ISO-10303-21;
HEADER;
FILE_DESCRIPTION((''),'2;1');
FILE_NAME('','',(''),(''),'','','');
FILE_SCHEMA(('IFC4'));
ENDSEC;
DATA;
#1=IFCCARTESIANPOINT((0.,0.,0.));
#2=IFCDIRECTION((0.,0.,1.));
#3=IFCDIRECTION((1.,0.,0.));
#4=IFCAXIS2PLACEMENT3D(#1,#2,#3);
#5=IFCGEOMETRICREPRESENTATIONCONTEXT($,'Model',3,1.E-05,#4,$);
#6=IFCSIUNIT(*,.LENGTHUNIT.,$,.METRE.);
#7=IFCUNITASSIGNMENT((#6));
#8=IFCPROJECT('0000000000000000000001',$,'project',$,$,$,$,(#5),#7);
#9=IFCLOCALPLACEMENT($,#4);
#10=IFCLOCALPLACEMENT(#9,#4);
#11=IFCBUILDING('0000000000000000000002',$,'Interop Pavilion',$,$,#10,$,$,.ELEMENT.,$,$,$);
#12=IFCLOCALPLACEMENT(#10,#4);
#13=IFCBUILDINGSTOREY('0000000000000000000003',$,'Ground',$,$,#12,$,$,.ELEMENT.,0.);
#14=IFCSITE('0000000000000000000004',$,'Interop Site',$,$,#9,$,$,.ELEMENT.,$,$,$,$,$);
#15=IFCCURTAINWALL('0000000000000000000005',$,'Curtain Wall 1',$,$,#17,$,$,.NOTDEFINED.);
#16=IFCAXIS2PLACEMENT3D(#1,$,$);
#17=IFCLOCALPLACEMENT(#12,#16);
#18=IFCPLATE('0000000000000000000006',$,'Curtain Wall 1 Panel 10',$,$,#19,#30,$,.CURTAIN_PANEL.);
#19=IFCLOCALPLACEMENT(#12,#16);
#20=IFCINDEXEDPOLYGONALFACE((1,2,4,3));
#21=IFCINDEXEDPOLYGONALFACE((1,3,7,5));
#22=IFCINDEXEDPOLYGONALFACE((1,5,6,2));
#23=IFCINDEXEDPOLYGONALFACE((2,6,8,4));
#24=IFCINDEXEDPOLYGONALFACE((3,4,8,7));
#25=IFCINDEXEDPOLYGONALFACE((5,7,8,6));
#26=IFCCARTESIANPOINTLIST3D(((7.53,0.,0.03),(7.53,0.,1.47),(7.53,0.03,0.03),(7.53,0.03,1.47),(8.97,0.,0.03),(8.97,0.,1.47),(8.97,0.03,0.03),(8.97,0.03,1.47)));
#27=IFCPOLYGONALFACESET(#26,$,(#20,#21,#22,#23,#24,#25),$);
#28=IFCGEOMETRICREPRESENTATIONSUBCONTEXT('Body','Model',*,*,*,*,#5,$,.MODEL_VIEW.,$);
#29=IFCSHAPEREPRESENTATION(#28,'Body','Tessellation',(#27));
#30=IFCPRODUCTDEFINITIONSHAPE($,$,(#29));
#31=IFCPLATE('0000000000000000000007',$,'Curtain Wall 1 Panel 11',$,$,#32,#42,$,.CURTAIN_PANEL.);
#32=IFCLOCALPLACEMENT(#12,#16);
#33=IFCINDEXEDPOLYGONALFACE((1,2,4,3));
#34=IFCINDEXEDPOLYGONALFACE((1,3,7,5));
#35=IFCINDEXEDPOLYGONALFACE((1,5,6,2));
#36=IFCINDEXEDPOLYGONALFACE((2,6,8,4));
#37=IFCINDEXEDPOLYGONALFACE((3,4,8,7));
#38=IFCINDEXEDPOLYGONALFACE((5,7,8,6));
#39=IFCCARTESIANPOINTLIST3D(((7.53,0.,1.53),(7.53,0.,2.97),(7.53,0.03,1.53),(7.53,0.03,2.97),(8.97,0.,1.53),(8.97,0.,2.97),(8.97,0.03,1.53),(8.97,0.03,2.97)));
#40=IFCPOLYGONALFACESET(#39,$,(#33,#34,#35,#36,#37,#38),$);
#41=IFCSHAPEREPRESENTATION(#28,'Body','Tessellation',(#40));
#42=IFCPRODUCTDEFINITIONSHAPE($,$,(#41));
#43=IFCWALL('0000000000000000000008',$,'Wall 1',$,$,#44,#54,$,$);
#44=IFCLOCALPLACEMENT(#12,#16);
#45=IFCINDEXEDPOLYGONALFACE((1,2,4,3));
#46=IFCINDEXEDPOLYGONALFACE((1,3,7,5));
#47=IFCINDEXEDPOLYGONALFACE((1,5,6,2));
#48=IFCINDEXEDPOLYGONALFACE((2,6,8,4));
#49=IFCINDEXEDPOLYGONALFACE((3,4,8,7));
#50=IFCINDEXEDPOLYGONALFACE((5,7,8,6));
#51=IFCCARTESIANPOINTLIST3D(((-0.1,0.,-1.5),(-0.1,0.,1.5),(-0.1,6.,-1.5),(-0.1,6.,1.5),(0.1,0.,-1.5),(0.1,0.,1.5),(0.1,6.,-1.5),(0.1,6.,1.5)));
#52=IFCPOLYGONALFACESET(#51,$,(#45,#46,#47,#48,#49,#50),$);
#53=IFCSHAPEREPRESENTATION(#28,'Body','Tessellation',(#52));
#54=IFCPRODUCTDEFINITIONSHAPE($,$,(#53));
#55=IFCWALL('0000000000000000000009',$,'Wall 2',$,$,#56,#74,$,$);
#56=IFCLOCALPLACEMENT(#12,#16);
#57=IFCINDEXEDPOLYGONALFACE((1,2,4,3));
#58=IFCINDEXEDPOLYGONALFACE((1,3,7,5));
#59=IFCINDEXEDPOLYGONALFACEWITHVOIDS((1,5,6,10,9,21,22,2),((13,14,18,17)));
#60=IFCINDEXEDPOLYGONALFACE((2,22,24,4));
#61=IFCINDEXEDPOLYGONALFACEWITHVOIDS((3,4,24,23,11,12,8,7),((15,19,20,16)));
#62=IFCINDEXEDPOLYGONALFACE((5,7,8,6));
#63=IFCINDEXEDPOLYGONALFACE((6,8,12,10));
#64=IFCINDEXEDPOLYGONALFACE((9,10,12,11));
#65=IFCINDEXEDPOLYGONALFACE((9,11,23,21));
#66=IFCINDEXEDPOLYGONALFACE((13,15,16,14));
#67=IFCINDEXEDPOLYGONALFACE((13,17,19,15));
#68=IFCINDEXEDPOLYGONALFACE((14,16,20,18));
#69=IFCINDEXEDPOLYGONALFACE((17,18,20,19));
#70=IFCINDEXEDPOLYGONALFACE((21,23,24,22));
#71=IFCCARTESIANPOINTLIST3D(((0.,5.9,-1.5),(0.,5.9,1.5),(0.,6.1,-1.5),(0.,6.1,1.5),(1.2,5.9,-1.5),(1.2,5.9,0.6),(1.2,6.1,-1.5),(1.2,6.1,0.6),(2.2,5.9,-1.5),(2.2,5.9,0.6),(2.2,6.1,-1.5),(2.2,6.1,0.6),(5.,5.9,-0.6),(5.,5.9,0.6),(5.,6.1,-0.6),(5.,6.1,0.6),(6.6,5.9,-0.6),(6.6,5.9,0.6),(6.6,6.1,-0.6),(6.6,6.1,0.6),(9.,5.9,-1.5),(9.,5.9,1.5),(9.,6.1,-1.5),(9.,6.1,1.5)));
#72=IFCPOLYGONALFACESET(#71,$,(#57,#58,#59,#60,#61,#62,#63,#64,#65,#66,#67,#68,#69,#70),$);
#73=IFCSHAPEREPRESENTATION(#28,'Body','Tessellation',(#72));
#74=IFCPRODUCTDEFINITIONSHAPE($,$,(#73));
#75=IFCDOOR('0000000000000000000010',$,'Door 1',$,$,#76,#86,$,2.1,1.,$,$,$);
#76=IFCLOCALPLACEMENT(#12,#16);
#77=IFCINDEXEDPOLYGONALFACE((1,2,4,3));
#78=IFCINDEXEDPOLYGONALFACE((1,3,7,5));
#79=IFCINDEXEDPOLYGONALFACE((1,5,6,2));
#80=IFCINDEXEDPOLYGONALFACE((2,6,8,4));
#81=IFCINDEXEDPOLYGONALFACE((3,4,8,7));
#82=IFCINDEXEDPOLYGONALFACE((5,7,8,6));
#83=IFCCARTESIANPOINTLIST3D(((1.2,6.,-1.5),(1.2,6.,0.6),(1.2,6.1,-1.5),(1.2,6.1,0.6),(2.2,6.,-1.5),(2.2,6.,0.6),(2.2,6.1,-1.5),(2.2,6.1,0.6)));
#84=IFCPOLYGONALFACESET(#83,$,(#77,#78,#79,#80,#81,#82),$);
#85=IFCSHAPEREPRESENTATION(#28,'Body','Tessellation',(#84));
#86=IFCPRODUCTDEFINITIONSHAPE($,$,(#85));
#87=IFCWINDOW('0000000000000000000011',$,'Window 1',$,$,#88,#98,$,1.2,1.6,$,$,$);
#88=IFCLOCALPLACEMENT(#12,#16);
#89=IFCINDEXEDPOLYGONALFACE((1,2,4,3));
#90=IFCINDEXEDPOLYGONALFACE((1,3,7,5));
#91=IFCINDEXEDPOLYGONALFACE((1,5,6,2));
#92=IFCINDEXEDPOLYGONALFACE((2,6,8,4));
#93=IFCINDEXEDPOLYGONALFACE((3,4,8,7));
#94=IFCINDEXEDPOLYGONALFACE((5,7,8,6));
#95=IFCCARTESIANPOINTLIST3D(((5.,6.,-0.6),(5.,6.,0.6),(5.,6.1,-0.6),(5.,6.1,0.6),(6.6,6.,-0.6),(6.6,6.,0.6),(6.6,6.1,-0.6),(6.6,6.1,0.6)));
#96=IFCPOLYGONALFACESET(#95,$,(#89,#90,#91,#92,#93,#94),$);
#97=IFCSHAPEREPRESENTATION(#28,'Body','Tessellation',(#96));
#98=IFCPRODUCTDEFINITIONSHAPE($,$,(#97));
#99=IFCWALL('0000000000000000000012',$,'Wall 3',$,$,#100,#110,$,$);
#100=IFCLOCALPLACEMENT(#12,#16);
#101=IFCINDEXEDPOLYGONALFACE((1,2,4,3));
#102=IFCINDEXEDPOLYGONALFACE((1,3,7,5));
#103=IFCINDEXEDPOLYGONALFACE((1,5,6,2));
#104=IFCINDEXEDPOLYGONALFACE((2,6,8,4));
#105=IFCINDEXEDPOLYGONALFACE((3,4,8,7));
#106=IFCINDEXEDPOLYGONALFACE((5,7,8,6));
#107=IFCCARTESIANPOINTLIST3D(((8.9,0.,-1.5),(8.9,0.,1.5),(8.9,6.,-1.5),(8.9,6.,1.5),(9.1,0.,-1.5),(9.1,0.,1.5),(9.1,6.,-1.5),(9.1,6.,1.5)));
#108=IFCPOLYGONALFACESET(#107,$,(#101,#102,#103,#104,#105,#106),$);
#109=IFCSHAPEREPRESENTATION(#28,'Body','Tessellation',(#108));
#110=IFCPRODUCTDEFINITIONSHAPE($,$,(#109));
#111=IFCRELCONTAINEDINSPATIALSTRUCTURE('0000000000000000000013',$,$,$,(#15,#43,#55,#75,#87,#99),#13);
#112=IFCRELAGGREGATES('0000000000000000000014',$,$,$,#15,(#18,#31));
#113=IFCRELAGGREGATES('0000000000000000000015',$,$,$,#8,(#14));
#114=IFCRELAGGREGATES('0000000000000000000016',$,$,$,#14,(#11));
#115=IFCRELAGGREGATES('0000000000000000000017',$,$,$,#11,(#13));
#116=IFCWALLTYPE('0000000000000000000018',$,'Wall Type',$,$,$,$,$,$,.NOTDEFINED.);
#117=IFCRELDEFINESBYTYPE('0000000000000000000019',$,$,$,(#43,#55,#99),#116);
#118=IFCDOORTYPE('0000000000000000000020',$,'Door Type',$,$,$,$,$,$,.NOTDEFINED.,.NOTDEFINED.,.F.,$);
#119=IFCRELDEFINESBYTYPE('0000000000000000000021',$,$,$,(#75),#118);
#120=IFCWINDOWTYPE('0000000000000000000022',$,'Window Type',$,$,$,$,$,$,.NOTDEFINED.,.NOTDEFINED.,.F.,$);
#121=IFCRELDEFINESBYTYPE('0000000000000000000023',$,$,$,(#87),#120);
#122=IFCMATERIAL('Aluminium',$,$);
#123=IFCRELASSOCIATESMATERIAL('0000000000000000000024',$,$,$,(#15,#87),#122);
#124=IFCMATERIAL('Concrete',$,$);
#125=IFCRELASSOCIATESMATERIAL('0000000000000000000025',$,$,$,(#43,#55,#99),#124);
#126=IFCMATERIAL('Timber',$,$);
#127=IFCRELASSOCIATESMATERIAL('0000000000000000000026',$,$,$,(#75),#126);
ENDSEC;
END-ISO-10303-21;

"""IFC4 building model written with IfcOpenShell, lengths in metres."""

from ifc_helpers import new_model, si_unit, frame, frame_2d, origin_with_axes, origin_2d, place, context, subcontext, project, spatial, rectangle, extrude, material, type_object, element, fill, aggregate, save


model = new_model("IFC4")

# Units and contexts
model_context = context("Model", 3, precision=1e-05, world=origin_with_axes())
body_context = subcontext(model_context, "Body", "Model", "MODEL_VIEW")
ifc_project = project(units=[si_unit("LENGTHUNIT", "METRE")], contexts=[model_context])

# Site, building, storey
site_placement = place(None, origin_with_axes())
site = spatial("IfcSite", under=ifc_project, at=site_placement, Name="Interop Site", CompositionType="ELEMENT")
building_placement = place(site_placement, origin_with_axes())
building = spatial("IfcBuilding", under=site, at=building_placement, Name="Interop Pavilion", CompositionType="ELEMENT")
storey_placement = place(building_placement, origin_with_axes())
storey = spatial("IfcBuildingStorey", under=building, at=storey_placement, Name="Ground", CompositionType="ELEMENT", Elevation=0.0)

# Shared definitions
ifc_material_1 = material(Name="Concrete")

# Curtain wall
ifc_material_2 = material(Name="Aluminium")
curtain_wall_placement = place(storey_placement, origin_with_axes())
curtain_wall = element("IfcCurtainWall", 1, at=curtain_wall_placement, inside=storey, material=ifc_material_2, Name="Curtain Wall 1", PredefinedType="NOTDEFINED")

# Plates
plate_1_placement = place(curtain_wall_placement, frame((7.53, 0.0, 0.03), z_axis=(0.0, 0.0, 1.0), x_axis=(1.0, 0.0, 0.0)))
plate_1 = element("IfcPlate", 2, at=plate_1_placement, Name="Curtain Wall 1 Panel 10", PredefinedType="CURTAIN_PANEL", context=body_context, shape_type="SweptSolid", body=[
    extrude(rectangle(XDim=1.44, YDim=0.03, at=frame_2d((0.72, 0.015))), origin_with_axes(), (0.0, 0.0, 1.0), 1.44),
])
plate_2_placement = place(curtain_wall_placement, frame((7.53, 0.0, 1.53), z_axis=(0.0, 0.0, 1.0), x_axis=(1.0, 0.0, 0.0)))
plate_2 = element("IfcPlate", 3, at=plate_2_placement, Name="Curtain Wall 1 Panel 11", PredefinedType="CURTAIN_PANEL", context=body_context, shape_type="SweptSolid", body=[
    extrude(rectangle(XDim=1.44, YDim=0.03, at=frame_2d((0.72, 0.015))), origin_with_axes(), (0.0, 0.0, 1.0), 1.44),
])
aggregate(curtain_wall, [plate_1, plate_2])

# Wall
wall_type = type_object("IfcWallType", Name="Wall Type", PredefinedType="NOTDEFINED")
wall_1_placement = place(storey_placement, frame((0.0, 0.0, 0.0), z_axis=(0.0, 0.0, 1.0), x_axis=(0.0, 1.0, 0.0)))
element("IfcWall", 4, at=wall_1_placement, inside=storey, type_object=wall_type, material=ifc_material_1, Name="Wall 1", context=body_context, shape_type="SweptSolid", body=[
    extrude(rectangle(XDim=0.2, YDim=3.0, at=origin_2d()), frame((0.0, 0.0, 0.0), z_axis=(1.0, 0.0, 0.0), x_axis=(0.0, 1.0, 0.0)), (0.0, 0.0, 1.0), 6.0),
])

# Wall, openings, door, window
wall_2_placement = place(storey_placement, frame((0.0, 6.0, 0.0), z_axis=(0.0, 0.0, 1.0), x_axis=(1.0, 0.0, 0.0)))
wall_2 = element("IfcWall", 5, at=wall_2_placement, inside=storey, type_object=wall_type, material=ifc_material_1, Name="Wall 2", context=body_context, shape_type="SweptSolid", body=[
    extrude(rectangle(XDim=0.2, YDim=3.0, at=origin_2d()), frame((0.0, 0.0, 0.0), z_axis=(1.0, 0.0, 0.0), x_axis=(0.0, 1.0, 0.0)), (0.0, 0.0, 1.0), 9.0),
])
opening_1_placement = place(wall_2_placement, frame((1.7, 0.1, -0.45), z_axis=(0.0, -1.0, 0.0), x_axis=(1.0, 0.0, 0.0)))
opening_1 = element("IfcOpeningElement", 6, at=opening_1_placement, cuts=wall_2, context=body_context, shape_type="SweptSolid", body=[
    extrude(rectangle(XDim=1.0, YDim=2.1, at=origin_2d()), origin_with_axes(), (0.0, 0.0, 1.0), 0.2),
])
opening_2_placement = place(wall_2_placement, frame((5.8, 0.1, 0.0), z_axis=(0.0, -1.0, 0.0), x_axis=(1.0, 0.0, 0.0)))
opening_2 = element("IfcOpeningElement", 7, at=opening_2_placement, cuts=wall_2, context=body_context, shape_type="SweptSolid", body=[
    extrude(rectangle(XDim=1.6, YDim=1.2, at=origin_2d()), origin_with_axes(), (0.0, 0.0, 1.0), 0.2),
])
ifc_material_3 = material(Name="Timber")
door_type = type_object("IfcDoorType", Name="Door Type", OperationType="NOTDEFINED", ParameterTakesPrecedence=False, PredefinedType="NOTDEFINED")
door_placement = place(opening_1_placement, origin_with_axes())
door = element("IfcDoor", 8, at=door_placement, inside=storey, type_object=door_type, material=ifc_material_3, Name="Door 1", OverallHeight=2.1, OverallWidth=1.0, context=body_context, shape_type="SweptSolid", body=[
    extrude(rectangle(XDim=1.0, YDim=2.1, at=origin_2d()), origin_with_axes(), (0.0, 0.0, 1.0), 0.1),
])
fill(opening_1, door)
window_type = type_object("IfcWindowType", Name="Window Type", ParameterTakesPrecedence=False, PartitioningType="NOTDEFINED", PredefinedType="NOTDEFINED")
window_placement = place(opening_2_placement, origin_with_axes())
window = element("IfcWindow", 9, at=window_placement, inside=storey, type_object=window_type, material=ifc_material_2, Name="Window 1", OverallHeight=1.2, OverallWidth=1.6, context=body_context, shape_type="SweptSolid", body=[
    extrude(rectangle(XDim=1.6, YDim=1.2, at=origin_2d()), origin_with_axes(), (0.0, 0.0, 1.0), 0.1),
])
fill(opening_2, window)

# Wall
wall_3_placement = place(storey_placement, frame((9.0, 6.0, 0.0), z_axis=(0.0, 0.0, 1.0), x_axis=(0.0, -1.0, 0.0)))
element("IfcWall", 10, at=wall_3_placement, inside=storey, type_object=wall_type, material=ifc_material_1, Name="Wall 3", context=body_context, shape_type="SweptSolid", body=[
    extrude(rectangle(XDim=0.2, YDim=3.0, at=origin_2d()), frame((0.0, 0.0, 0.0), z_axis=(1.0, 0.0, 0.0), x_axis=(0.0, 1.0, 0.0)), (0.0, 0.0, 1.0), 6.0),
])

save(model, "model.ifc")
